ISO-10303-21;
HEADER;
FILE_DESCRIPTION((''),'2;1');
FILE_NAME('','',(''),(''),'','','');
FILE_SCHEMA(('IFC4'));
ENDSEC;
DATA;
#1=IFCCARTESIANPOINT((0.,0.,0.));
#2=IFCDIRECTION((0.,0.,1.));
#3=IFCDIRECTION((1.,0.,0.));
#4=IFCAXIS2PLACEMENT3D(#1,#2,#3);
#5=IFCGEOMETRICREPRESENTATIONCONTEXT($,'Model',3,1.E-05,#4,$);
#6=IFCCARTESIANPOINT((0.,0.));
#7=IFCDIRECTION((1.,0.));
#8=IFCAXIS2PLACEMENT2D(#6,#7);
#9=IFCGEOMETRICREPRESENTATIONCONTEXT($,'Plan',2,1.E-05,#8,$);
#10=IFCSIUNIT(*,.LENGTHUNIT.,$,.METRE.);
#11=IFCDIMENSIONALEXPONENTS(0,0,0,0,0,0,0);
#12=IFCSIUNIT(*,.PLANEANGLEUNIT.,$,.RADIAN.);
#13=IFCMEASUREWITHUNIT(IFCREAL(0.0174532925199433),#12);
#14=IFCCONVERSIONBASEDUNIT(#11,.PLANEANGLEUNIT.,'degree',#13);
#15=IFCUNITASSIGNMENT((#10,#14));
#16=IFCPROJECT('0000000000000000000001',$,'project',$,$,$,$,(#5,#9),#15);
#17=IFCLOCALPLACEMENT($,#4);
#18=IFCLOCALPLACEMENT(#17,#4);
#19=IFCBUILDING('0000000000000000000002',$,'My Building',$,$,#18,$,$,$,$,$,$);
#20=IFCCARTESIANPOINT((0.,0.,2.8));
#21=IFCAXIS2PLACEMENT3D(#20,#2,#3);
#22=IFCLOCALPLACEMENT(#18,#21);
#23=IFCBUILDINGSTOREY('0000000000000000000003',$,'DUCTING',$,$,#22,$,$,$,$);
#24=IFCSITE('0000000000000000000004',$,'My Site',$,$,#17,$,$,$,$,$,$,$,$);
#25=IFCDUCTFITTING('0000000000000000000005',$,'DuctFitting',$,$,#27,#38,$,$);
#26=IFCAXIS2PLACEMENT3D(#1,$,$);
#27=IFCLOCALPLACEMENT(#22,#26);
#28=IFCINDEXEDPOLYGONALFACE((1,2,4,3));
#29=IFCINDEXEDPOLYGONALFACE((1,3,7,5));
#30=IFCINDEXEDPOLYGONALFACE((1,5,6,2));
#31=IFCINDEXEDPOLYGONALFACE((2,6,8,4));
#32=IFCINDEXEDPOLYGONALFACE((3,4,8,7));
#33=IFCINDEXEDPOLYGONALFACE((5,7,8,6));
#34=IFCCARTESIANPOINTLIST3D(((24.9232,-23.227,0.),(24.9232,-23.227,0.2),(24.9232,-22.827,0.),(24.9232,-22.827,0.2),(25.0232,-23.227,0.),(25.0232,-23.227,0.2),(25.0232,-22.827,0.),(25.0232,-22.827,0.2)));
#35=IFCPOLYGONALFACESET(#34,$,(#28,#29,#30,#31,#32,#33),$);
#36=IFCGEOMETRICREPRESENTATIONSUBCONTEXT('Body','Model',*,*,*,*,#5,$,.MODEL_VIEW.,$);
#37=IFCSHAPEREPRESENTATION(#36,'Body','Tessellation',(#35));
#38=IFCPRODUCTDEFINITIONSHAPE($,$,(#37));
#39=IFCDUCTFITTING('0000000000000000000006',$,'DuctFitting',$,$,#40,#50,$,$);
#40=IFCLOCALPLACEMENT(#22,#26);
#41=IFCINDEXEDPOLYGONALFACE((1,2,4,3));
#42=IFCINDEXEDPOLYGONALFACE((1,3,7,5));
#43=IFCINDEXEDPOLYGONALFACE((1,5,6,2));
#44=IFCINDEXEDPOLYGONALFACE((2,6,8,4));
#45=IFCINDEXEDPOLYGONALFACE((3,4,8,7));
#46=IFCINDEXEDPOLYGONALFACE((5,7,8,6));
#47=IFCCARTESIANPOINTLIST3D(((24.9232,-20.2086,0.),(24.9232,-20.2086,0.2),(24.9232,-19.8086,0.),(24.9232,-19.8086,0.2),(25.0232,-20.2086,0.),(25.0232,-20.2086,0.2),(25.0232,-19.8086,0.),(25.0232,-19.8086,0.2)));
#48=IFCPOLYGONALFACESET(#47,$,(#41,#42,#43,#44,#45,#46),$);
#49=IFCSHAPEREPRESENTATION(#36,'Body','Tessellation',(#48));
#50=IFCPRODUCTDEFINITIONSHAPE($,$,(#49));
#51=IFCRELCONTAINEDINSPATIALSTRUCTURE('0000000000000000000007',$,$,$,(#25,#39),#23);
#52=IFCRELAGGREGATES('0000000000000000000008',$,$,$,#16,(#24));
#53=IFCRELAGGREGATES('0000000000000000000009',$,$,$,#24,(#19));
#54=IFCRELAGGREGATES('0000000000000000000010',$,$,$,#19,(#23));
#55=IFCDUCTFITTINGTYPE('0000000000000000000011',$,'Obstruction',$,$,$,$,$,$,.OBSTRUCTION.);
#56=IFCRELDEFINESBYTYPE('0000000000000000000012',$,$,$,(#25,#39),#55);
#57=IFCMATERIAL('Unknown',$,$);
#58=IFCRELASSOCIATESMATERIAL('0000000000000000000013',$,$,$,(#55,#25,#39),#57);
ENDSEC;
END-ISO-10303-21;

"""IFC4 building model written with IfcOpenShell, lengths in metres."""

from ifc_helpers import new_model, entity, si_unit, converted_unit, frame, origin_with_axes, origin_2d_with_axis, place, context, subcontext, project, spatial, rectangle, extrude, material, material_profile, profile_set, profile_usage, type_object, element, save


model = new_model("IFC4")

# Units and contexts
model_context = context("Model", 3, precision=1e-05, world=origin_with_axes())
plan_context = context("Plan", 2, precision=1e-05, world=origin_2d_with_axis())
body_context = subcontext(model_context, "Body", "Model", "MODEL_VIEW")
ifc_project = project(units=[si_unit("LENGTHUNIT", "METRE"), converted_unit("PLANEANGLEUNIT", "degree", entity("IfcReal", 0.0174532925199433), si_unit("PLANEANGLEUNIT", "RADIAN"), dimensions=[0, 0, 0, 0, 0, 0, 0])], contexts=[model_context, plan_context])

# Site, building, storey
site_placement = place(None, origin_with_axes())
site = spatial("IfcSite", under=ifc_project, at=site_placement, Name="My Site")
building_placement = place(site_placement, origin_with_axes())
building = spatial("IfcBuilding", under=site, at=building_placement, Name="My Building")
storey_placement = place(building_placement, frame((0.0, 0.0, 2.8), z_axis=(0.0, 0.0, 1.0), x_axis=(1.0, 0.0, 0.0)))
storey = spatial("IfcBuildingStorey", under=building, at=storey_placement, Name="DUCTING")

# Shared definitions
ifc_material = material(Name="Unknown")

# Duct fittings
ifc_material_profile_1 = material_profile(ifc_material, rectangle(XDim=0.4, YDim=0.2))
ifc_profile_set_1 = profile_set([ifc_material_profile_1])
duct_fitting_type_1 = type_object("IfcDuctFittingType", Name="Obstruction", PredefinedType="OBSTRUCTION", material=ifc_profile_set_1)
ifc_profile_usage_1 = profile_usage(ifc_profile_set_1, cardinal=5)
duct_fitting_1_placement = place(storey_placement, frame((24.9232, -23.027, 0.1), z_axis=(1.0, 0.0, 0.0), x_axis=(0.0, 1.0, 0.0)))
element("IfcDuctFitting", 1, at=duct_fitting_1_placement, inside=storey, type_object=duct_fitting_type_1, material=ifc_profile_usage_1, Name="DuctFitting", context=body_context, shape_type="SweptSolid", body=[
    extrude(rectangle(XDim=0.4, YDim=0.2), origin_with_axes(), (0.0, 0.0, 1.0), 0.1),
])
ifc_profile_usage_2 = profile_usage(ifc_profile_set_1, cardinal=5)
duct_fitting_2_placement = place(storey_placement, frame((24.9232, -20.0086, 0.1), z_axis=(1.0, 0.0, 0.0), x_axis=(0.0, 1.0, 0.0)))
element("IfcDuctFitting", 2, at=duct_fitting_2_placement, inside=storey, type_object=duct_fitting_type_1, material=ifc_profile_usage_2, Name="DuctFitting", context=body_context, shape_type="SweptSolid", body=[
    extrude(rectangle(XDim=0.4, YDim=0.2), origin_with_axes(), (0.0, 0.0, 1.0), 0.1),
])

save(model, "model.ifc")
